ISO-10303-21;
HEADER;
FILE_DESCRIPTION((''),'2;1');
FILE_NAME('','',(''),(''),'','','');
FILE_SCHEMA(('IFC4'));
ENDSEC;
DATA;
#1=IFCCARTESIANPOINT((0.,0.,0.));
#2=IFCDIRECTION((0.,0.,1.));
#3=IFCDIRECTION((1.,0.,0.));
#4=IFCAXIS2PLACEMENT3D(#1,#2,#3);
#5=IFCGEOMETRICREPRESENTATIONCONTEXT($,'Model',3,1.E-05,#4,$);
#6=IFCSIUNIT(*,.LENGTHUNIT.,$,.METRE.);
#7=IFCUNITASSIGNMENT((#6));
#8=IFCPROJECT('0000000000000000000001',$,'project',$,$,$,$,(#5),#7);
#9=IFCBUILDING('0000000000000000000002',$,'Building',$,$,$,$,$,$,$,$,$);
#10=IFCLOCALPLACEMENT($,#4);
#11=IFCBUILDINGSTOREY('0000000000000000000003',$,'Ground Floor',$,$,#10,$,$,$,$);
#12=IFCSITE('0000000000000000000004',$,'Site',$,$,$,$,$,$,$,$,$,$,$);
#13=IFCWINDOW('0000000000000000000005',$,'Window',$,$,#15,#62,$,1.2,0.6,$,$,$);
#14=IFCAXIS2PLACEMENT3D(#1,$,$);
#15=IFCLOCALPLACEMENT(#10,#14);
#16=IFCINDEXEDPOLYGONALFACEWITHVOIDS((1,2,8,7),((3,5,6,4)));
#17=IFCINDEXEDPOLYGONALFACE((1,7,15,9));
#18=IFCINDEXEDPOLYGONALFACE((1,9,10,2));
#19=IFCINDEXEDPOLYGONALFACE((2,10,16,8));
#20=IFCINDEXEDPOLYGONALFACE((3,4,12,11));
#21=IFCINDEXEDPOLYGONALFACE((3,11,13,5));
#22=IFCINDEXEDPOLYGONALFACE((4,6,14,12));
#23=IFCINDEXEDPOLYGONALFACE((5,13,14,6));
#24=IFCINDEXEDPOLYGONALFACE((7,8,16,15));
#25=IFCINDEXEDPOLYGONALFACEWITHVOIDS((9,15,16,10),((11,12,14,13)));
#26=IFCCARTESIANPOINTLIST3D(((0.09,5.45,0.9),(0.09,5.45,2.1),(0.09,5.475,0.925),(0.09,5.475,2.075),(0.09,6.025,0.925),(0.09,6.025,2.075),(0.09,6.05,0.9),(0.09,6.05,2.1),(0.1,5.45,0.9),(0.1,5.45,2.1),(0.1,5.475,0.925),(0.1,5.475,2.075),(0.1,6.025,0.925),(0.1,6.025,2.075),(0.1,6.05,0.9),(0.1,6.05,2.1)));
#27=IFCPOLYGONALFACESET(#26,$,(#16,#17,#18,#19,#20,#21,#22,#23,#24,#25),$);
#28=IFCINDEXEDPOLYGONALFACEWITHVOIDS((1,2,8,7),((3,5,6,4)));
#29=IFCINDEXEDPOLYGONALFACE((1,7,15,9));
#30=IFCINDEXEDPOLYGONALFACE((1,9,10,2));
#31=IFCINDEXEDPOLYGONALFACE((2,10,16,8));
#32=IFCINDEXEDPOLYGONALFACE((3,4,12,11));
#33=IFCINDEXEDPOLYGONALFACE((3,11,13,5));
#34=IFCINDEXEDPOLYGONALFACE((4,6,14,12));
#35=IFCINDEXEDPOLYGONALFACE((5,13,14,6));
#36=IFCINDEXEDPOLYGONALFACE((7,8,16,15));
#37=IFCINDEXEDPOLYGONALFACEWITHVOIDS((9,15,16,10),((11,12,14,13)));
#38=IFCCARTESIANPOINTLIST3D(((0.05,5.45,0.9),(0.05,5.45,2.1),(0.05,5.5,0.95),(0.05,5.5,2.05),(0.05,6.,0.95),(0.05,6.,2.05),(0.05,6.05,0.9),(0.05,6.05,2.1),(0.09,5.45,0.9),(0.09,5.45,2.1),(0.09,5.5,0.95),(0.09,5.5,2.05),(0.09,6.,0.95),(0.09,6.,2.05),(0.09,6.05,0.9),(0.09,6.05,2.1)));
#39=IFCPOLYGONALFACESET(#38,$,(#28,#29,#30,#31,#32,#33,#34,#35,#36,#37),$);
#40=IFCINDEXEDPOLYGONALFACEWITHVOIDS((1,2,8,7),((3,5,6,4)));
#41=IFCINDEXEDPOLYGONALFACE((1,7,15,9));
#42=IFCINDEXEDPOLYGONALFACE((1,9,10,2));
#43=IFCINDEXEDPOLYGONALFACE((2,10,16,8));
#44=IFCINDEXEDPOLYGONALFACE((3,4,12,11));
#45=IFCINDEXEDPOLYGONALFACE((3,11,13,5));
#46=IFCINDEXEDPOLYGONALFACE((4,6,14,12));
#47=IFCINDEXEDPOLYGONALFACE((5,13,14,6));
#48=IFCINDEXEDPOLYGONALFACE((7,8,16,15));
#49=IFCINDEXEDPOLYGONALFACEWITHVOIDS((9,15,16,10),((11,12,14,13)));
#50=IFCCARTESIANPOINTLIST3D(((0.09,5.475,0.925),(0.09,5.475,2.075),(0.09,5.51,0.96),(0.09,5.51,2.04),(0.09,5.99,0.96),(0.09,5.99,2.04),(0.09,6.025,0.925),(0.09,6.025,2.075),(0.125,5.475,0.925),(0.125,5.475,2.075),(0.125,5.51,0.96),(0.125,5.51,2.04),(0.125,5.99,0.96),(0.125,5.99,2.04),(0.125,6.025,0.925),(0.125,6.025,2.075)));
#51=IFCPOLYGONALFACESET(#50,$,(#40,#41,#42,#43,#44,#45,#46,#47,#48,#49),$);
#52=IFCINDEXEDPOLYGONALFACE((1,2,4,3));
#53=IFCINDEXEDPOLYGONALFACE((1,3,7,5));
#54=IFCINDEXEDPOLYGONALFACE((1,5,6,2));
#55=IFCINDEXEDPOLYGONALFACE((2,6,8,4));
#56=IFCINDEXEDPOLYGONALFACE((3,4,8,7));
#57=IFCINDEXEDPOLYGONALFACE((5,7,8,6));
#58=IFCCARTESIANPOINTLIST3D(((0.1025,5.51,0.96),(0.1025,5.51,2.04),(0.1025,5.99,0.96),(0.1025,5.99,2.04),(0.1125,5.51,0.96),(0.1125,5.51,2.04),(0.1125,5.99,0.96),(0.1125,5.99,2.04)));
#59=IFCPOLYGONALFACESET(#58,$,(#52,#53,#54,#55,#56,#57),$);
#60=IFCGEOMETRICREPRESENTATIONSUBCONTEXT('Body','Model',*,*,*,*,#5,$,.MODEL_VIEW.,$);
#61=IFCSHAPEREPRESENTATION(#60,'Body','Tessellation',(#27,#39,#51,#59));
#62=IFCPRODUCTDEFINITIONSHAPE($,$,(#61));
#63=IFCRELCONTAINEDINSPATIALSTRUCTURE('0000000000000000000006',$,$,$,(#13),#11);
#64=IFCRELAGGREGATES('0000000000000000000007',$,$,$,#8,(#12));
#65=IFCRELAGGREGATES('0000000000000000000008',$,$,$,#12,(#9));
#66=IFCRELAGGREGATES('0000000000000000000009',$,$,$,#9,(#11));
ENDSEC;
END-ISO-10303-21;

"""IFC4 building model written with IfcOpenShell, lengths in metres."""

from ifc_helpers import new_model, si_unit, frame, origin_with_axes, place, context, subcontext, project, spatial, line, indexed_curve, outline, extrude, element, save


model = new_model("IFC4")

# Units and contexts
model_context = context("Model", 3, precision=1e-05, world=origin_with_axes())
body_context = subcontext(model_context, "Body", "Model", "MODEL_VIEW")
ifc_project = project(units=[si_unit("LENGTHUNIT", "METRE")], contexts=[model_context])

# Site, building, storey
site = spatial("IfcSite", under=ifc_project, Name="Site")
building = spatial("IfcBuilding", under=site, Name="Building")
storey_placement = place(None, origin_with_axes())
storey = spatial("IfcBuildingStorey", under=building, at=storey_placement, Name="Ground Floor")

# Window
window_1_placement = place(storey_placement, frame((0.0, 6.05, 0.9), z_axis=(0.0, 0.0, 1.0), x_axis=(0.0, -1.0, 0.0)))
element("IfcWindow", 1, at=window_1_placement, inside=storey, Name="Window", OverallHeight=1.2, OverallWidth=0.6, context=body_context, shape_type="SweptSolid", body=[
    extrude(outline(indexed_curve([(0.0, 0.0), (0.6, 0.0), (0.6, 1.2), (0.0, 1.2)], segments=[line(1, 2, 3, 4, 1)]), holes=[indexed_curve([(0.025, 0.025), (0.575, 0.025), (0.575, 1.175), (0.025, 1.175)], segments=[line(1, 2, 3, 4, 1)])]), frame((0.0, 0.09, 0.0), z_axis=(0.0, -1.0, 0.0), x_axis=(1.0, 0.0, 0.0)), (0.0, 0.0, -1.0), 0.01),
    extrude(outline(indexed_curve([(0.0, 0.0), (0.6, 0.0), (0.6, 1.2), (0.0, 1.2)], segments=[line(1, 2, 3, 4, 1)]), holes=[indexed_curve([(0.05, 0.05), (0.55, 0.05), (0.55, 1.15), (0.05, 1.15)], segments=[line(1, 2, 3, 4, 1)])]), frame((0.0, 0.05, 0.0), z_axis=(0.0, -1.0, 0.0), x_axis=(1.0, 0.0, 0.0)), (0.0, 0.0, -1.0), 0.04),
    extrude(outline(indexed_curve([(0.0, 0.0), (0.55, 0.0), (0.55, 1.15), (0.0, 1.15)], segments=[line(1, 2, 3, 4, 1)]), holes=[indexed_curve([(0.035, 0.035), (0.515, 0.035), (0.515, 1.115), (0.035, 1.115)], segments=[line(1, 2, 3, 4, 1)])]), frame((0.025, 0.09, 0.025), z_axis=(0.0, -1.0, 0.0), x_axis=(1.0, 0.0, 0.0)), (0.0, 0.0, -1.0), 0.035),
    extrude(outline(indexed_curve([(0.035, 0.035), (0.515, 0.035), (0.515, 1.115), (0.035, 1.115)], segments=[line(1, 2, 3, 4, 1)])), frame((0.025, 0.1025, 0.025), z_axis=(0.0, -1.0, 0.0), x_axis=(1.0, 0.0, 0.0)), (0.0, 0.0, -1.0), 0.01),
])

save(model, "model.ifc")
